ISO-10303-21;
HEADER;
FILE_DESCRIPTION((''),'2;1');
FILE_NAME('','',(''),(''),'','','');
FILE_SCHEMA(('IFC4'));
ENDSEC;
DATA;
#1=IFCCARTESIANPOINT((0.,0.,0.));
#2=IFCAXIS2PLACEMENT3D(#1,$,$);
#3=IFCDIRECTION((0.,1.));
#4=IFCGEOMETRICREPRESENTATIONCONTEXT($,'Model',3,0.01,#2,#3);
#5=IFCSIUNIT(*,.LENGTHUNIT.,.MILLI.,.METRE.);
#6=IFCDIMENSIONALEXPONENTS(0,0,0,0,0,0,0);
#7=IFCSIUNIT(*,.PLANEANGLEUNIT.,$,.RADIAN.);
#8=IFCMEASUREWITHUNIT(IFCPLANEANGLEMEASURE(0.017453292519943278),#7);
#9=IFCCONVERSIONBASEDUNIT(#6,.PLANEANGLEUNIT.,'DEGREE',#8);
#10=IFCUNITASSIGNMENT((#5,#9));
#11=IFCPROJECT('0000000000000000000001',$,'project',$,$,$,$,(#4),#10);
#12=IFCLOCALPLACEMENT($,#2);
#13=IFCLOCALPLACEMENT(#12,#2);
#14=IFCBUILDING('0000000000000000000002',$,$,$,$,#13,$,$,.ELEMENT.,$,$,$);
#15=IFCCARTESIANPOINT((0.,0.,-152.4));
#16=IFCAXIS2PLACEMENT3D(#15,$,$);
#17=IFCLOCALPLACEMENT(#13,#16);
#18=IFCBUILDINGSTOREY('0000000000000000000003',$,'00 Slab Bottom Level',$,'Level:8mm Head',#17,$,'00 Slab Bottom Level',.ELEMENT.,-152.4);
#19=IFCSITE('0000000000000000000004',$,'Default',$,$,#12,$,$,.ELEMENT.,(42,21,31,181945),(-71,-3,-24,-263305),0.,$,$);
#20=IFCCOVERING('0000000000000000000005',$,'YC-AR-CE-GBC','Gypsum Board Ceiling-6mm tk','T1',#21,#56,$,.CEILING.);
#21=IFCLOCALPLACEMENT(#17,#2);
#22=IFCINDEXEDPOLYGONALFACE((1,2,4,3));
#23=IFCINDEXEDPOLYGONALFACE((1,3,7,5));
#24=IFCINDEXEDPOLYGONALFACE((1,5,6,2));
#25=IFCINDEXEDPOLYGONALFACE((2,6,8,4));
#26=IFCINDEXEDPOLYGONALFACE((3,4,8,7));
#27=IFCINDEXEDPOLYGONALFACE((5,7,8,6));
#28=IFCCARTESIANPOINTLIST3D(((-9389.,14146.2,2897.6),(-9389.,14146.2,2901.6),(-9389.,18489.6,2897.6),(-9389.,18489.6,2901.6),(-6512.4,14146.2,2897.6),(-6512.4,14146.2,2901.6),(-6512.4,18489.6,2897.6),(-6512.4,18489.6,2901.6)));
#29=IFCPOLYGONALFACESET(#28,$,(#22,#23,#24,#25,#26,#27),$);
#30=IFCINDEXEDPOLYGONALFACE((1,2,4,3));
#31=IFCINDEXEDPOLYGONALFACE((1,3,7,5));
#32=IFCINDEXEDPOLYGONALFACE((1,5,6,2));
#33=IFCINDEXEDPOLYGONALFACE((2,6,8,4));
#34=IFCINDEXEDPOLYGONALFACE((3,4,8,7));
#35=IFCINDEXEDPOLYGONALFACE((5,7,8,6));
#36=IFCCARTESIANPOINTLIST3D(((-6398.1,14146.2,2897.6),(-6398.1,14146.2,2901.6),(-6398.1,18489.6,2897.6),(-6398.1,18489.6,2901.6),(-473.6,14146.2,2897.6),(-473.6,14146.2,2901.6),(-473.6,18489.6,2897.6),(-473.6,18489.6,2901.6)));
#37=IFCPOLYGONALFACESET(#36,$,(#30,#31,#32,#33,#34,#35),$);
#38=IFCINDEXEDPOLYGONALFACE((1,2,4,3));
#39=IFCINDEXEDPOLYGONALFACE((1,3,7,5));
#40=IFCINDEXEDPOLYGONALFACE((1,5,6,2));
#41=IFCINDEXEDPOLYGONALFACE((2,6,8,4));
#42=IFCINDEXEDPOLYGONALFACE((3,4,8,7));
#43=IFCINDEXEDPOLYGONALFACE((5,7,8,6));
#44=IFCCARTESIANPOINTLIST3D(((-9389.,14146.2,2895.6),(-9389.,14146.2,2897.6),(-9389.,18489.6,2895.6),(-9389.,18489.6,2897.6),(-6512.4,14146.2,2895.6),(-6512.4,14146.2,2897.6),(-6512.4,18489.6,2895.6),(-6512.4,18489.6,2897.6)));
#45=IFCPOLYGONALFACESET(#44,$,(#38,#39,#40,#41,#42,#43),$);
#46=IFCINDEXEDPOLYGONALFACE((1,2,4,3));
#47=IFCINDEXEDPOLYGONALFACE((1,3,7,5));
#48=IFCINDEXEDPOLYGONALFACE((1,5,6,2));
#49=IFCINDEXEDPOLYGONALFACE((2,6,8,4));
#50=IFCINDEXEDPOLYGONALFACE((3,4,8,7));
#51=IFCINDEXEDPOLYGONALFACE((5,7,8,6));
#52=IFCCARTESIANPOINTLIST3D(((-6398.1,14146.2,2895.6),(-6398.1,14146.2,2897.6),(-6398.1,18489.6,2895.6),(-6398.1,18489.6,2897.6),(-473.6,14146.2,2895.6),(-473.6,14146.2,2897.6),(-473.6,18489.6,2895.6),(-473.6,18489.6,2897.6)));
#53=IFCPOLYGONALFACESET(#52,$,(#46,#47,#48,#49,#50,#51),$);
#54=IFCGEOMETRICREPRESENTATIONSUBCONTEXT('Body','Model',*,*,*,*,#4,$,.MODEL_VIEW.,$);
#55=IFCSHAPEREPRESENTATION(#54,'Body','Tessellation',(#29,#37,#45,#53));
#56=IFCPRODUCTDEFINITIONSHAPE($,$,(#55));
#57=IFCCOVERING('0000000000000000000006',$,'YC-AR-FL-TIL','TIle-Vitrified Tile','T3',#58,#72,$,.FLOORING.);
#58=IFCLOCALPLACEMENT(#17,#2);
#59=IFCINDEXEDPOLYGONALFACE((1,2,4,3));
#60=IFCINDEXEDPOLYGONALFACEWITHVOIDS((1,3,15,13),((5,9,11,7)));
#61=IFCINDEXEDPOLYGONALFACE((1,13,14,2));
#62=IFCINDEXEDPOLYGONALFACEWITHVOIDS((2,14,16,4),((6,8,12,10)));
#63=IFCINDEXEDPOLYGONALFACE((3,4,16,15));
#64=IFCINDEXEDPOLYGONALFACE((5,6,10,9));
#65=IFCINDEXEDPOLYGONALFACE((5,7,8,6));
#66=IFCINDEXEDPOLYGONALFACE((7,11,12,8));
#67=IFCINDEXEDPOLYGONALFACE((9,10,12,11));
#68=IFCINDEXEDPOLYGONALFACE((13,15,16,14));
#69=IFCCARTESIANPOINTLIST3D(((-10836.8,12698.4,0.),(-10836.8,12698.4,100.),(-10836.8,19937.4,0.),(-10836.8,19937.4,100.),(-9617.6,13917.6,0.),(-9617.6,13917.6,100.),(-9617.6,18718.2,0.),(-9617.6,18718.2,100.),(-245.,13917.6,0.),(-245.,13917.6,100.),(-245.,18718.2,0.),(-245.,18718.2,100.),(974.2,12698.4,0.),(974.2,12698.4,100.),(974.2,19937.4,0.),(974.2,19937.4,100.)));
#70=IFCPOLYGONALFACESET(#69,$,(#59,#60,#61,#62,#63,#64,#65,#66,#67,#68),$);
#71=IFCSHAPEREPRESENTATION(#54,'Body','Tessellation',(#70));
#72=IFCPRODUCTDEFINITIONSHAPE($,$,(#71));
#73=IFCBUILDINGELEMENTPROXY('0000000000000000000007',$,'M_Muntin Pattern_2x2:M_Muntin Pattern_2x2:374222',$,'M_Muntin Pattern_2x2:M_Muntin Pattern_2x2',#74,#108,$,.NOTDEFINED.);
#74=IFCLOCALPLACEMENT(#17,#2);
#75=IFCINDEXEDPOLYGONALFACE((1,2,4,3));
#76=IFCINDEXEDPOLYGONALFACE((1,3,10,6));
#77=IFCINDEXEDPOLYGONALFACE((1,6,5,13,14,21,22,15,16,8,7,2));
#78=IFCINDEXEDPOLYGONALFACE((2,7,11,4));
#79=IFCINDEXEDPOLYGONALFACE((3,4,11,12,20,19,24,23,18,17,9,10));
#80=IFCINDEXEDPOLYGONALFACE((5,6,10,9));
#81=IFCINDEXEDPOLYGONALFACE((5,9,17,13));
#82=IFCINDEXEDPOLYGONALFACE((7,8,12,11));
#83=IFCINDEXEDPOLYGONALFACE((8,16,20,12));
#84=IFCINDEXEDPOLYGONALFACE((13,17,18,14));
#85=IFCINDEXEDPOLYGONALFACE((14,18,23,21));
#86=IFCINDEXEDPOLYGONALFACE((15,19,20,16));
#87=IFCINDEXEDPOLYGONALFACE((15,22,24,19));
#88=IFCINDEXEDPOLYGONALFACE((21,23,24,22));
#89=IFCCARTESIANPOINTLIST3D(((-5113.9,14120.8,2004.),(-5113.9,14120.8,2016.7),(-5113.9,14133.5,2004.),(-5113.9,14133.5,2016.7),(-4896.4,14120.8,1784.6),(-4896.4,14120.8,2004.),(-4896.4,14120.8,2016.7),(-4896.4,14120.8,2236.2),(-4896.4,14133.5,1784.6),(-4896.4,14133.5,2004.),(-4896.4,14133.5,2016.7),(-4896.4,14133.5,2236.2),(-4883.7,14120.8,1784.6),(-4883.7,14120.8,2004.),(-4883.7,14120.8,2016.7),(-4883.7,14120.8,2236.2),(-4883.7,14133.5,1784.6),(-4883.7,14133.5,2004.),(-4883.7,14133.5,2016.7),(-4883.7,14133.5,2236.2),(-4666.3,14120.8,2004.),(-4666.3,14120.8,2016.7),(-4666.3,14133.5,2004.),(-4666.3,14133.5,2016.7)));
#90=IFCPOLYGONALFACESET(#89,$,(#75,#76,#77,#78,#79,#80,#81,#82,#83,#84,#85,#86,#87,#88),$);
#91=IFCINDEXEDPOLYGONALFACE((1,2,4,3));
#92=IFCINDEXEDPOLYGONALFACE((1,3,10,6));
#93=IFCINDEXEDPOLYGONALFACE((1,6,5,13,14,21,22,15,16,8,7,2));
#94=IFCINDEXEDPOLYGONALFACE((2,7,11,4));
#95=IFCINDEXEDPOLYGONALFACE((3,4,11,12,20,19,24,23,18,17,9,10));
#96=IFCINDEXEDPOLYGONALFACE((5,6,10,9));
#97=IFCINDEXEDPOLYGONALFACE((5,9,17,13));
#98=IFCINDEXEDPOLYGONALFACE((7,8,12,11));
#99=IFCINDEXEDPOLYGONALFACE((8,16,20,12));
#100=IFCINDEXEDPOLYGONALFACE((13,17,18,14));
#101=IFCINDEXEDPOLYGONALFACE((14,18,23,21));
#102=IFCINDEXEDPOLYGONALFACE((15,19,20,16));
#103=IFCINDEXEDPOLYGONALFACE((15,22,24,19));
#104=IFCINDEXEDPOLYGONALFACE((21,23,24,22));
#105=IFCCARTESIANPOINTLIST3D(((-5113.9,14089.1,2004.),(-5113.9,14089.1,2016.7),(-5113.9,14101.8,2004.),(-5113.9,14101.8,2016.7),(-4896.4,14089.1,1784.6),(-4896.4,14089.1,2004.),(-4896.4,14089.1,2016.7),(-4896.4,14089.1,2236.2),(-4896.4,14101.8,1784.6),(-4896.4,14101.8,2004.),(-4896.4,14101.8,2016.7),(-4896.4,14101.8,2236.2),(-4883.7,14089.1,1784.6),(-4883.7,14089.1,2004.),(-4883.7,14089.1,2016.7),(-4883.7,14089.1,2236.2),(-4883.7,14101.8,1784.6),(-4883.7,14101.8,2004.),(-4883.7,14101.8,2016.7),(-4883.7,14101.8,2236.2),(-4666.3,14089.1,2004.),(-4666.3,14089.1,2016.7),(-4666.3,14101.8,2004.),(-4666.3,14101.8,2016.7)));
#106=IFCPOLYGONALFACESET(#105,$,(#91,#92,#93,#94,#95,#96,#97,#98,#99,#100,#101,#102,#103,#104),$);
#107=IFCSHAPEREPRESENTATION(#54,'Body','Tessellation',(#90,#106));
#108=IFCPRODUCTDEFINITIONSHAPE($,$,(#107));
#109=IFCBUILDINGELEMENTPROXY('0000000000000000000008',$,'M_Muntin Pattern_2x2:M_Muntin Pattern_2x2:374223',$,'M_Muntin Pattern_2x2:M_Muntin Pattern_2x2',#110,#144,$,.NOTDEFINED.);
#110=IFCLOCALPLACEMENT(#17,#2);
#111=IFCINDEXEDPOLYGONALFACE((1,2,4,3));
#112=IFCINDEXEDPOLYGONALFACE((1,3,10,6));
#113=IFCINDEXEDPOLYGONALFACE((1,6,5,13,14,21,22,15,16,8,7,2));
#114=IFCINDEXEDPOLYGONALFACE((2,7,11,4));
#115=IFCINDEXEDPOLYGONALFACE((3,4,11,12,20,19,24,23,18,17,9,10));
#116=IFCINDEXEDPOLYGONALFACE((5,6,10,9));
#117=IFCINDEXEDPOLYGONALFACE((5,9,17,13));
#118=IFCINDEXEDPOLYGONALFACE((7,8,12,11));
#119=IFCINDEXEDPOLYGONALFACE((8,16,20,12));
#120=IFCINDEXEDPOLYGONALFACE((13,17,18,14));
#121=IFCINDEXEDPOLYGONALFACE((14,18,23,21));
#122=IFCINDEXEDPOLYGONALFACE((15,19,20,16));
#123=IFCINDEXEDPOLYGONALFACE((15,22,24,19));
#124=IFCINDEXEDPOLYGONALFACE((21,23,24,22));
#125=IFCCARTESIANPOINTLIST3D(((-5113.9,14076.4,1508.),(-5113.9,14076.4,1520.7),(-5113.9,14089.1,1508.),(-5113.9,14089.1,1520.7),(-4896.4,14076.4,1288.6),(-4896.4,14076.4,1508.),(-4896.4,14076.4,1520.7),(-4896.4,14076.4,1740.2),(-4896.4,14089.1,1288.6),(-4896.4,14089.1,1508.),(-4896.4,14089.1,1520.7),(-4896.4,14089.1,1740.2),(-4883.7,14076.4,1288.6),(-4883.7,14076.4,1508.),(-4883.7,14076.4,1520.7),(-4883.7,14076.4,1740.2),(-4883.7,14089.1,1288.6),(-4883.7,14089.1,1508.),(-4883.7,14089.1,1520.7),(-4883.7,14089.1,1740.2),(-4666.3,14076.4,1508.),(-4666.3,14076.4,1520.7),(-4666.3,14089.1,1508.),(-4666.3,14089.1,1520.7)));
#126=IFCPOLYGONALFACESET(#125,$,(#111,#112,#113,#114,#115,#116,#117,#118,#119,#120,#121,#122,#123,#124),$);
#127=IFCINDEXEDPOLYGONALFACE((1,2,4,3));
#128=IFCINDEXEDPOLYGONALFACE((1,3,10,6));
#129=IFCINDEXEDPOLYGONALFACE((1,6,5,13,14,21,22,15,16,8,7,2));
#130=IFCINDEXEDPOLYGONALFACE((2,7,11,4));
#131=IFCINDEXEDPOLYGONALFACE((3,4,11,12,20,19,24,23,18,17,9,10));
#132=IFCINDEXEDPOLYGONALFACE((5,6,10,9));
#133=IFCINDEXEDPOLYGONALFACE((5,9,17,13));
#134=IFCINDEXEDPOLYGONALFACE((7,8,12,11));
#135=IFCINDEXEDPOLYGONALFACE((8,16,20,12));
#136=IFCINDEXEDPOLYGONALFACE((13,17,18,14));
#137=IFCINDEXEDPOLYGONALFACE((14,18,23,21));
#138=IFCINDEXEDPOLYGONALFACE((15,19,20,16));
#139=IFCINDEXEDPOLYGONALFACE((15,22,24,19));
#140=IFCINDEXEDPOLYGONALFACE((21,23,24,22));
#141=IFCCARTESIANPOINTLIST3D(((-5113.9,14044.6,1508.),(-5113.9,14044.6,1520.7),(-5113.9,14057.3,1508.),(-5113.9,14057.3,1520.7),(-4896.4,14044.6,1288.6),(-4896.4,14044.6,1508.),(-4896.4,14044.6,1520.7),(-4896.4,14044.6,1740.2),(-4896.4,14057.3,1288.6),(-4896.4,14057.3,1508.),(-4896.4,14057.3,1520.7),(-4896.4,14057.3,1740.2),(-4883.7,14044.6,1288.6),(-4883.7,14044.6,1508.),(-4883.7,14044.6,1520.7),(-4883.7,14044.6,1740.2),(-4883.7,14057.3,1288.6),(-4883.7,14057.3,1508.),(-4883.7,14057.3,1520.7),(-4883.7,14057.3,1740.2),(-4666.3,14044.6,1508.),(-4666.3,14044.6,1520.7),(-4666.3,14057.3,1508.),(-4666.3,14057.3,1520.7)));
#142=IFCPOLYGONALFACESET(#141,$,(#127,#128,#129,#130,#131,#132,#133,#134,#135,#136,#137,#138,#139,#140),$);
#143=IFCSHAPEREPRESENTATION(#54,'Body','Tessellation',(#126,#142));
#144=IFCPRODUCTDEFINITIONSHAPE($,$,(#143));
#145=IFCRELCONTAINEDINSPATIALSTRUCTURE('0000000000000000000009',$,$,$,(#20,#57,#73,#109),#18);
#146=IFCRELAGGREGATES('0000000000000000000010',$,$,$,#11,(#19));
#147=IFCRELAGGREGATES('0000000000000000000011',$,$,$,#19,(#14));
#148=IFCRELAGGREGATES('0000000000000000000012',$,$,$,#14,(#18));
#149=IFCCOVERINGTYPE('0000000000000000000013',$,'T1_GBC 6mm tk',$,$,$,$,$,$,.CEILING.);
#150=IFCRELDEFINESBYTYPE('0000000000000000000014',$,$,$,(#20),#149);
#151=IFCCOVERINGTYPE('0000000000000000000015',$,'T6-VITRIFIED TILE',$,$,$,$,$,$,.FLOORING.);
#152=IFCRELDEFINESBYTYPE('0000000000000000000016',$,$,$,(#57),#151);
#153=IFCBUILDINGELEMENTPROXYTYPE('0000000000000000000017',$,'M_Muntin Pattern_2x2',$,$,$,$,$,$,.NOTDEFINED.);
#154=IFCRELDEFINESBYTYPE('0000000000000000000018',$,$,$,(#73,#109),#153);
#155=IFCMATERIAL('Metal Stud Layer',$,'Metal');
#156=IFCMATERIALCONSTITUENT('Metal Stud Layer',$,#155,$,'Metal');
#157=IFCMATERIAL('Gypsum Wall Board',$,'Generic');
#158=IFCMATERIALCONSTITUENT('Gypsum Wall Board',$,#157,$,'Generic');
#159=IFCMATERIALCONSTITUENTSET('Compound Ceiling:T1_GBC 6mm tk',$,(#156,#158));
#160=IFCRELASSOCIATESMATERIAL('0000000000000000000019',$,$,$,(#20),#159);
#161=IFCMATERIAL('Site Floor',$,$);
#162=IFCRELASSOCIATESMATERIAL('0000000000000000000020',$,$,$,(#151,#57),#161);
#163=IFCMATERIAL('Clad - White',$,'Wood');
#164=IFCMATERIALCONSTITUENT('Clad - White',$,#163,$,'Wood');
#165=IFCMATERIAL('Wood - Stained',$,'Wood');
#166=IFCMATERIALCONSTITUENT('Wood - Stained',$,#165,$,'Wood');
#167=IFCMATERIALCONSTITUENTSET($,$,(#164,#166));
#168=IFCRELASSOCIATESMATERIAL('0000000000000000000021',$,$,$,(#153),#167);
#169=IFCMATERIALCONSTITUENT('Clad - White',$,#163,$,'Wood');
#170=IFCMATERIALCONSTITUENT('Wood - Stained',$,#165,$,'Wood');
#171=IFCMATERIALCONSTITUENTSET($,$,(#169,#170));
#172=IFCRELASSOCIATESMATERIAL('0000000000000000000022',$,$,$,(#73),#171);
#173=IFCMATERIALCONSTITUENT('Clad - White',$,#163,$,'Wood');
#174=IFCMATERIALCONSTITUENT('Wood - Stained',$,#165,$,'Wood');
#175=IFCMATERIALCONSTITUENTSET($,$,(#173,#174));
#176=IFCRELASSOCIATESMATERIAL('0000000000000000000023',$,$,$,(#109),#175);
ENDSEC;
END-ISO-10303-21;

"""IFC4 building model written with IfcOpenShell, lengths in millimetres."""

from ifc_helpers import new_model, entity, si_unit, converted_unit, direction, frame, origin, place, context, subcontext, project, spatial, indexed_curve, outline, extrude, source, transform, mapped, material, constituent, constituent_set, type_object, type_shapes, element, save


model = new_model("IFC4")

# Units and contexts
model_context = context("Model", 3, precision=0.01, world=origin(), true_north=direction((0.0, 1.0)))
body_context = subcontext(model_context, "Body", "Model", "MODEL_VIEW")
ifc_project = project(units=[si_unit("LENGTHUNIT", "METRE", prefix="MILLI"), converted_unit("PLANEANGLEUNIT", "DEGREE", entity("IfcPlaneAngleMeasure", 0.017453292519943278), si_unit("PLANEANGLEUNIT", "RADIAN"), dimensions=[0, 0, 0, 0, 0, 0, 0])], contexts=[model_context])

# Site, building, storey
site_placement = place(None, origin())
site = spatial("IfcSite", under=ifc_project, at=site_placement, Name="Default", CompositionType="ELEMENT", RefLatitude=(42, 21, 31, 181945), RefLongitude=(-71, -3, -24, -263305), RefElevation=0.0)
building_placement = place(site_placement, origin())
building = spatial("IfcBuilding", under=site, at=building_placement, CompositionType="ELEMENT")
storey_placement = place(building_placement, frame((0.0, 0.0, -152.4)))
storey = spatial("IfcBuildingStorey", under=building, at=storey_placement, Name="00 Slab Bottom Level", ObjectType="Level:8mm Head", LongName="00 Slab Bottom Level", CompositionType="ELEMENT", Elevation=-152.4)

# Covering
ifc_material_1 = material(Name="Metal Stud Layer", Category="Metal")
ifc_constituent_1 = constituent(ifc_material_1, Name="Metal Stud Layer", Category="Metal")
ifc_material_2 = material(Name="Gypsum Wall Board", Category="Generic")
ifc_constituent_2 = constituent(ifc_material_2, Name="Gypsum Wall Board", Category="Generic")
ifc_constituent_set_1 = constituent_set(constituents=[ifc_constituent_1, ifc_constituent_2], Name="Compound Ceiling:T1_GBC 6mm tk")
covering_type_1 = type_object("IfcCoveringType", Name="T1_GBC 6mm tk", PredefinedType="CEILING")
covering_1_placement = place(storey_placement, frame((-9389.0, 14146.2, 2895.6)))
element("IfcCovering", 1, at=covering_1_placement, inside=storey, type_object=covering_type_1, material=ifc_constituent_set_1, Name="YC-AR-CE-GBC", Description="Gypsum Board Ceiling-6mm tk", ObjectType="T1", PredefinedType="CEILING", context=body_context, shape_type="SweptSolid", body=[
    extrude(outline(indexed_curve([(-2171.7, -1438.3), (2171.7, -1438.3), (2171.7, 1438.3), (-2171.7, 1438.3), (-2171.7, -1438.3)], self_intersect=False)), frame((1438.3, 2171.7, 2.0), z_axis=(0.0, 0.0, 1.0), x_axis=(0.0, -1.0, 0.0)), (0.0, 0.0, 1.0), 4.0),
    extrude(outline(indexed_curve([(-2171.7, -2962.3), (2171.7, -2962.3), (2171.7, 2962.3), (-2171.7, 2962.3), (-2171.7, -2962.3)], self_intersect=False)), frame((5953.1, 2171.7, 2.0), z_axis=(0.0, 0.0, 1.0), x_axis=(0.0, -1.0, 0.0)), (0.0, 0.0, 1.0), 4.0),
    extrude(outline(indexed_curve([(-1438.3, -2171.7), (1438.3, -2171.7), (1438.3, 2171.7), (-1438.3, 2171.7), (-1438.3, -2171.7)], self_intersect=False)), frame((1438.3, 2171.7, 0.0), z_axis=(0.0, 0.0, 1.0), x_axis=(-1.0, 0.0, 0.0)), (0.0, 0.0, 1.0), 2.0),
    extrude(outline(indexed_curve([(-2962.3, -2171.7), (2962.3, -2171.7), (2962.3, 2171.7), (-2962.3, 2171.7), (-2962.3, -2171.7)], self_intersect=False)), frame((5953.1, 2171.7, 0.0), z_axis=(0.0, 0.0, 1.0), x_axis=(-1.0, 0.0, 0.0)), (0.0, 0.0, 1.0), 2.0),
])

# Covering, opening
ifc_material_3 = material(Name="Site Floor")
covering_type_2 = type_object("IfcCoveringType", Name="T6-VITRIFIED TILE", PredefinedType="FLOORING", material=ifc_material_3)
covering_2_placement = place(storey_placement, origin())
covering_2 = element("IfcCovering", 2, at=covering_2_placement, inside=storey, type_object=covering_type_2, material=ifc_material_3, Name="YC-AR-FL-TIL", Description="TIle-Vitrified Tile", ObjectType="T3", PredefinedType="FLOORING", context=body_context, shape_type="SweptSolid", body=[
    extrude(outline(indexed_curve([(-3619.5, -5905.5), (3619.5, -5905.5), (3619.5, 5905.5), (-3619.5, 5905.5), (-3619.5, -5905.5)], self_intersect=False), holes=[indexed_curve([(-2400.3, 4686.3), (2400.3, 4686.3), (2400.3, -4686.3), (-2400.3, -4686.3), (-2400.3, 4686.3)], self_intersect=False)]), frame((-4931.3, 16317.9, 0.0), z_axis=(0.0, 0.0, 1.0), x_axis=(0.0, -1.0, 0.0)), (0.0, 0.0, 1.0), 100.0),
])
opening_placement = place(covering_2_placement, origin())
element("IfcOpeningElement", 3, at=opening_placement, cuts=covering_2, PredefinedType="OPENING", context=body_context, shape_type="SweptSolid", body=[
    extrude(outline(indexed_curve([(-2400.3, -4686.3), (2400.3, -4686.3), (2400.3, 4686.3), (-2400.3, 4686.3), (-2400.3, -4686.3)], self_intersect=False)), frame((-4931.3, 16317.9, 100.0), z_axis=(0.0, 0.0, -1.0), x_axis=(0.0, -1.0, 0.0)), (0.0, 0.0, 1.0), 11811.0),
])

# Building element proxies
ifc_material_4 = material(Name="Clad - White", Category="Wood")
ifc_constituent_3 = constituent(ifc_material_4, Name="Clad - White", Category="Wood")
ifc_material_5 = material(Name="Wood - Stained", Category="Wood")
ifc_constituent_4 = constituent(ifc_material_5, Name="Wood - Stained", Category="Wood")
ifc_constituent_set_2 = constituent_set(constituents=[ifc_constituent_3, ifc_constituent_4])
ifc_constituent_5 = constituent(ifc_material_4, Name="Clad - White", Category="Wood")
ifc_constituent_6 = constituent(ifc_material_5, Name="Wood - Stained", Category="Wood")
ifc_constituent_set_3 = constituent_set(constituents=[ifc_constituent_5, ifc_constituent_6])
building_element_proxy_type_1 = type_object("IfcBuildingElementProxyType", Name="M_Muntin Pattern_2x2", PredefinedType="NOTDEFINED", material=ifc_constituent_set_3)
shared_shape_1 = source(origin(), body_context, "Body", "SweptSolid", [
    extrude(outline(indexed_curve([(6.4, -6.4), (225.8, -6.4), (225.8, 6.3), (6.4, 6.3), (6.4, 223.8), (-6.3, 223.8), (-6.3, 6.3), (-225.8, 6.3), (-225.8, -6.4), (-6.3, -6.4), (-6.3, -223.8), (6.4, -223.8), (6.4, -6.4)], self_intersect=False)), frame((0.0, 9.5, 225.8), z_axis=(0.0, 1.0, 0.0), x_axis=(0.0, 0.0, 1.0)), (0.0, 0.0, 1.0), 12.7),
    extrude(outline(indexed_curve([(6.4, -6.4), (225.8, -6.4), (225.8, 6.3), (6.4, 6.3), (6.4, 223.8), (-6.3, 223.8), (-6.3, 6.3), (-225.8, 6.3), (-225.8, -6.4), (-6.3, -6.4), (-6.3, -223.8), (6.4, -223.8), (6.4, -6.4)], self_intersect=False)), frame((0.0, -22.2, 225.8), z_axis=(0.0, 1.0, 0.0), x_axis=(0.0, 0.0, 1.0)), (0.0, 0.0, 1.0), 12.7),
])
type_shapes(building_element_proxy_type_1, [shared_shape_1])
proxy_1_placement = place(storey_placement, frame((-4890.1, 14111.3, 1784.6)))
element("IfcBuildingElementProxy", 4, at=proxy_1_placement, inside=storey, type_object=building_element_proxy_type_1, material=ifc_constituent_set_2, Name="M_Muntin Pattern_2x2:M_Muntin Pattern_2x2:374222", ObjectType="M_Muntin Pattern_2x2:M_Muntin Pattern_2x2", PredefinedType="NOTDEFINED", context=body_context, shape_type="MappedRepresentation", body=[
    mapped(shared_shape_1, transform((0.0, 0.0, 0.0), scale=1.0)),
])
ifc_constituent_7 = constituent(ifc_material_4, Name="Clad - White", Category="Wood")
ifc_constituent_8 = constituent(ifc_material_5, Name="Wood - Stained", Category="Wood")
ifc_constituent_set_4 = constituent_set(constituents=[ifc_constituent_7, ifc_constituent_8])
proxy_2_placement = place(storey_placement, frame((-4890.1, 14066.9, 1288.6)))
element("IfcBuildingElementProxy", 5, at=proxy_2_placement, inside=storey, type_object=building_element_proxy_type_1, material=ifc_constituent_set_4, Name="M_Muntin Pattern_2x2:M_Muntin Pattern_2x2:374223", ObjectType="M_Muntin Pattern_2x2:M_Muntin Pattern_2x2", PredefinedType="NOTDEFINED", context=body_context, shape_type="MappedRepresentation", body=[
    mapped(shared_shape_1, transform((0.0, 0.0, 0.0), scale=1.0)),
])

save(model, "model.ifc")
